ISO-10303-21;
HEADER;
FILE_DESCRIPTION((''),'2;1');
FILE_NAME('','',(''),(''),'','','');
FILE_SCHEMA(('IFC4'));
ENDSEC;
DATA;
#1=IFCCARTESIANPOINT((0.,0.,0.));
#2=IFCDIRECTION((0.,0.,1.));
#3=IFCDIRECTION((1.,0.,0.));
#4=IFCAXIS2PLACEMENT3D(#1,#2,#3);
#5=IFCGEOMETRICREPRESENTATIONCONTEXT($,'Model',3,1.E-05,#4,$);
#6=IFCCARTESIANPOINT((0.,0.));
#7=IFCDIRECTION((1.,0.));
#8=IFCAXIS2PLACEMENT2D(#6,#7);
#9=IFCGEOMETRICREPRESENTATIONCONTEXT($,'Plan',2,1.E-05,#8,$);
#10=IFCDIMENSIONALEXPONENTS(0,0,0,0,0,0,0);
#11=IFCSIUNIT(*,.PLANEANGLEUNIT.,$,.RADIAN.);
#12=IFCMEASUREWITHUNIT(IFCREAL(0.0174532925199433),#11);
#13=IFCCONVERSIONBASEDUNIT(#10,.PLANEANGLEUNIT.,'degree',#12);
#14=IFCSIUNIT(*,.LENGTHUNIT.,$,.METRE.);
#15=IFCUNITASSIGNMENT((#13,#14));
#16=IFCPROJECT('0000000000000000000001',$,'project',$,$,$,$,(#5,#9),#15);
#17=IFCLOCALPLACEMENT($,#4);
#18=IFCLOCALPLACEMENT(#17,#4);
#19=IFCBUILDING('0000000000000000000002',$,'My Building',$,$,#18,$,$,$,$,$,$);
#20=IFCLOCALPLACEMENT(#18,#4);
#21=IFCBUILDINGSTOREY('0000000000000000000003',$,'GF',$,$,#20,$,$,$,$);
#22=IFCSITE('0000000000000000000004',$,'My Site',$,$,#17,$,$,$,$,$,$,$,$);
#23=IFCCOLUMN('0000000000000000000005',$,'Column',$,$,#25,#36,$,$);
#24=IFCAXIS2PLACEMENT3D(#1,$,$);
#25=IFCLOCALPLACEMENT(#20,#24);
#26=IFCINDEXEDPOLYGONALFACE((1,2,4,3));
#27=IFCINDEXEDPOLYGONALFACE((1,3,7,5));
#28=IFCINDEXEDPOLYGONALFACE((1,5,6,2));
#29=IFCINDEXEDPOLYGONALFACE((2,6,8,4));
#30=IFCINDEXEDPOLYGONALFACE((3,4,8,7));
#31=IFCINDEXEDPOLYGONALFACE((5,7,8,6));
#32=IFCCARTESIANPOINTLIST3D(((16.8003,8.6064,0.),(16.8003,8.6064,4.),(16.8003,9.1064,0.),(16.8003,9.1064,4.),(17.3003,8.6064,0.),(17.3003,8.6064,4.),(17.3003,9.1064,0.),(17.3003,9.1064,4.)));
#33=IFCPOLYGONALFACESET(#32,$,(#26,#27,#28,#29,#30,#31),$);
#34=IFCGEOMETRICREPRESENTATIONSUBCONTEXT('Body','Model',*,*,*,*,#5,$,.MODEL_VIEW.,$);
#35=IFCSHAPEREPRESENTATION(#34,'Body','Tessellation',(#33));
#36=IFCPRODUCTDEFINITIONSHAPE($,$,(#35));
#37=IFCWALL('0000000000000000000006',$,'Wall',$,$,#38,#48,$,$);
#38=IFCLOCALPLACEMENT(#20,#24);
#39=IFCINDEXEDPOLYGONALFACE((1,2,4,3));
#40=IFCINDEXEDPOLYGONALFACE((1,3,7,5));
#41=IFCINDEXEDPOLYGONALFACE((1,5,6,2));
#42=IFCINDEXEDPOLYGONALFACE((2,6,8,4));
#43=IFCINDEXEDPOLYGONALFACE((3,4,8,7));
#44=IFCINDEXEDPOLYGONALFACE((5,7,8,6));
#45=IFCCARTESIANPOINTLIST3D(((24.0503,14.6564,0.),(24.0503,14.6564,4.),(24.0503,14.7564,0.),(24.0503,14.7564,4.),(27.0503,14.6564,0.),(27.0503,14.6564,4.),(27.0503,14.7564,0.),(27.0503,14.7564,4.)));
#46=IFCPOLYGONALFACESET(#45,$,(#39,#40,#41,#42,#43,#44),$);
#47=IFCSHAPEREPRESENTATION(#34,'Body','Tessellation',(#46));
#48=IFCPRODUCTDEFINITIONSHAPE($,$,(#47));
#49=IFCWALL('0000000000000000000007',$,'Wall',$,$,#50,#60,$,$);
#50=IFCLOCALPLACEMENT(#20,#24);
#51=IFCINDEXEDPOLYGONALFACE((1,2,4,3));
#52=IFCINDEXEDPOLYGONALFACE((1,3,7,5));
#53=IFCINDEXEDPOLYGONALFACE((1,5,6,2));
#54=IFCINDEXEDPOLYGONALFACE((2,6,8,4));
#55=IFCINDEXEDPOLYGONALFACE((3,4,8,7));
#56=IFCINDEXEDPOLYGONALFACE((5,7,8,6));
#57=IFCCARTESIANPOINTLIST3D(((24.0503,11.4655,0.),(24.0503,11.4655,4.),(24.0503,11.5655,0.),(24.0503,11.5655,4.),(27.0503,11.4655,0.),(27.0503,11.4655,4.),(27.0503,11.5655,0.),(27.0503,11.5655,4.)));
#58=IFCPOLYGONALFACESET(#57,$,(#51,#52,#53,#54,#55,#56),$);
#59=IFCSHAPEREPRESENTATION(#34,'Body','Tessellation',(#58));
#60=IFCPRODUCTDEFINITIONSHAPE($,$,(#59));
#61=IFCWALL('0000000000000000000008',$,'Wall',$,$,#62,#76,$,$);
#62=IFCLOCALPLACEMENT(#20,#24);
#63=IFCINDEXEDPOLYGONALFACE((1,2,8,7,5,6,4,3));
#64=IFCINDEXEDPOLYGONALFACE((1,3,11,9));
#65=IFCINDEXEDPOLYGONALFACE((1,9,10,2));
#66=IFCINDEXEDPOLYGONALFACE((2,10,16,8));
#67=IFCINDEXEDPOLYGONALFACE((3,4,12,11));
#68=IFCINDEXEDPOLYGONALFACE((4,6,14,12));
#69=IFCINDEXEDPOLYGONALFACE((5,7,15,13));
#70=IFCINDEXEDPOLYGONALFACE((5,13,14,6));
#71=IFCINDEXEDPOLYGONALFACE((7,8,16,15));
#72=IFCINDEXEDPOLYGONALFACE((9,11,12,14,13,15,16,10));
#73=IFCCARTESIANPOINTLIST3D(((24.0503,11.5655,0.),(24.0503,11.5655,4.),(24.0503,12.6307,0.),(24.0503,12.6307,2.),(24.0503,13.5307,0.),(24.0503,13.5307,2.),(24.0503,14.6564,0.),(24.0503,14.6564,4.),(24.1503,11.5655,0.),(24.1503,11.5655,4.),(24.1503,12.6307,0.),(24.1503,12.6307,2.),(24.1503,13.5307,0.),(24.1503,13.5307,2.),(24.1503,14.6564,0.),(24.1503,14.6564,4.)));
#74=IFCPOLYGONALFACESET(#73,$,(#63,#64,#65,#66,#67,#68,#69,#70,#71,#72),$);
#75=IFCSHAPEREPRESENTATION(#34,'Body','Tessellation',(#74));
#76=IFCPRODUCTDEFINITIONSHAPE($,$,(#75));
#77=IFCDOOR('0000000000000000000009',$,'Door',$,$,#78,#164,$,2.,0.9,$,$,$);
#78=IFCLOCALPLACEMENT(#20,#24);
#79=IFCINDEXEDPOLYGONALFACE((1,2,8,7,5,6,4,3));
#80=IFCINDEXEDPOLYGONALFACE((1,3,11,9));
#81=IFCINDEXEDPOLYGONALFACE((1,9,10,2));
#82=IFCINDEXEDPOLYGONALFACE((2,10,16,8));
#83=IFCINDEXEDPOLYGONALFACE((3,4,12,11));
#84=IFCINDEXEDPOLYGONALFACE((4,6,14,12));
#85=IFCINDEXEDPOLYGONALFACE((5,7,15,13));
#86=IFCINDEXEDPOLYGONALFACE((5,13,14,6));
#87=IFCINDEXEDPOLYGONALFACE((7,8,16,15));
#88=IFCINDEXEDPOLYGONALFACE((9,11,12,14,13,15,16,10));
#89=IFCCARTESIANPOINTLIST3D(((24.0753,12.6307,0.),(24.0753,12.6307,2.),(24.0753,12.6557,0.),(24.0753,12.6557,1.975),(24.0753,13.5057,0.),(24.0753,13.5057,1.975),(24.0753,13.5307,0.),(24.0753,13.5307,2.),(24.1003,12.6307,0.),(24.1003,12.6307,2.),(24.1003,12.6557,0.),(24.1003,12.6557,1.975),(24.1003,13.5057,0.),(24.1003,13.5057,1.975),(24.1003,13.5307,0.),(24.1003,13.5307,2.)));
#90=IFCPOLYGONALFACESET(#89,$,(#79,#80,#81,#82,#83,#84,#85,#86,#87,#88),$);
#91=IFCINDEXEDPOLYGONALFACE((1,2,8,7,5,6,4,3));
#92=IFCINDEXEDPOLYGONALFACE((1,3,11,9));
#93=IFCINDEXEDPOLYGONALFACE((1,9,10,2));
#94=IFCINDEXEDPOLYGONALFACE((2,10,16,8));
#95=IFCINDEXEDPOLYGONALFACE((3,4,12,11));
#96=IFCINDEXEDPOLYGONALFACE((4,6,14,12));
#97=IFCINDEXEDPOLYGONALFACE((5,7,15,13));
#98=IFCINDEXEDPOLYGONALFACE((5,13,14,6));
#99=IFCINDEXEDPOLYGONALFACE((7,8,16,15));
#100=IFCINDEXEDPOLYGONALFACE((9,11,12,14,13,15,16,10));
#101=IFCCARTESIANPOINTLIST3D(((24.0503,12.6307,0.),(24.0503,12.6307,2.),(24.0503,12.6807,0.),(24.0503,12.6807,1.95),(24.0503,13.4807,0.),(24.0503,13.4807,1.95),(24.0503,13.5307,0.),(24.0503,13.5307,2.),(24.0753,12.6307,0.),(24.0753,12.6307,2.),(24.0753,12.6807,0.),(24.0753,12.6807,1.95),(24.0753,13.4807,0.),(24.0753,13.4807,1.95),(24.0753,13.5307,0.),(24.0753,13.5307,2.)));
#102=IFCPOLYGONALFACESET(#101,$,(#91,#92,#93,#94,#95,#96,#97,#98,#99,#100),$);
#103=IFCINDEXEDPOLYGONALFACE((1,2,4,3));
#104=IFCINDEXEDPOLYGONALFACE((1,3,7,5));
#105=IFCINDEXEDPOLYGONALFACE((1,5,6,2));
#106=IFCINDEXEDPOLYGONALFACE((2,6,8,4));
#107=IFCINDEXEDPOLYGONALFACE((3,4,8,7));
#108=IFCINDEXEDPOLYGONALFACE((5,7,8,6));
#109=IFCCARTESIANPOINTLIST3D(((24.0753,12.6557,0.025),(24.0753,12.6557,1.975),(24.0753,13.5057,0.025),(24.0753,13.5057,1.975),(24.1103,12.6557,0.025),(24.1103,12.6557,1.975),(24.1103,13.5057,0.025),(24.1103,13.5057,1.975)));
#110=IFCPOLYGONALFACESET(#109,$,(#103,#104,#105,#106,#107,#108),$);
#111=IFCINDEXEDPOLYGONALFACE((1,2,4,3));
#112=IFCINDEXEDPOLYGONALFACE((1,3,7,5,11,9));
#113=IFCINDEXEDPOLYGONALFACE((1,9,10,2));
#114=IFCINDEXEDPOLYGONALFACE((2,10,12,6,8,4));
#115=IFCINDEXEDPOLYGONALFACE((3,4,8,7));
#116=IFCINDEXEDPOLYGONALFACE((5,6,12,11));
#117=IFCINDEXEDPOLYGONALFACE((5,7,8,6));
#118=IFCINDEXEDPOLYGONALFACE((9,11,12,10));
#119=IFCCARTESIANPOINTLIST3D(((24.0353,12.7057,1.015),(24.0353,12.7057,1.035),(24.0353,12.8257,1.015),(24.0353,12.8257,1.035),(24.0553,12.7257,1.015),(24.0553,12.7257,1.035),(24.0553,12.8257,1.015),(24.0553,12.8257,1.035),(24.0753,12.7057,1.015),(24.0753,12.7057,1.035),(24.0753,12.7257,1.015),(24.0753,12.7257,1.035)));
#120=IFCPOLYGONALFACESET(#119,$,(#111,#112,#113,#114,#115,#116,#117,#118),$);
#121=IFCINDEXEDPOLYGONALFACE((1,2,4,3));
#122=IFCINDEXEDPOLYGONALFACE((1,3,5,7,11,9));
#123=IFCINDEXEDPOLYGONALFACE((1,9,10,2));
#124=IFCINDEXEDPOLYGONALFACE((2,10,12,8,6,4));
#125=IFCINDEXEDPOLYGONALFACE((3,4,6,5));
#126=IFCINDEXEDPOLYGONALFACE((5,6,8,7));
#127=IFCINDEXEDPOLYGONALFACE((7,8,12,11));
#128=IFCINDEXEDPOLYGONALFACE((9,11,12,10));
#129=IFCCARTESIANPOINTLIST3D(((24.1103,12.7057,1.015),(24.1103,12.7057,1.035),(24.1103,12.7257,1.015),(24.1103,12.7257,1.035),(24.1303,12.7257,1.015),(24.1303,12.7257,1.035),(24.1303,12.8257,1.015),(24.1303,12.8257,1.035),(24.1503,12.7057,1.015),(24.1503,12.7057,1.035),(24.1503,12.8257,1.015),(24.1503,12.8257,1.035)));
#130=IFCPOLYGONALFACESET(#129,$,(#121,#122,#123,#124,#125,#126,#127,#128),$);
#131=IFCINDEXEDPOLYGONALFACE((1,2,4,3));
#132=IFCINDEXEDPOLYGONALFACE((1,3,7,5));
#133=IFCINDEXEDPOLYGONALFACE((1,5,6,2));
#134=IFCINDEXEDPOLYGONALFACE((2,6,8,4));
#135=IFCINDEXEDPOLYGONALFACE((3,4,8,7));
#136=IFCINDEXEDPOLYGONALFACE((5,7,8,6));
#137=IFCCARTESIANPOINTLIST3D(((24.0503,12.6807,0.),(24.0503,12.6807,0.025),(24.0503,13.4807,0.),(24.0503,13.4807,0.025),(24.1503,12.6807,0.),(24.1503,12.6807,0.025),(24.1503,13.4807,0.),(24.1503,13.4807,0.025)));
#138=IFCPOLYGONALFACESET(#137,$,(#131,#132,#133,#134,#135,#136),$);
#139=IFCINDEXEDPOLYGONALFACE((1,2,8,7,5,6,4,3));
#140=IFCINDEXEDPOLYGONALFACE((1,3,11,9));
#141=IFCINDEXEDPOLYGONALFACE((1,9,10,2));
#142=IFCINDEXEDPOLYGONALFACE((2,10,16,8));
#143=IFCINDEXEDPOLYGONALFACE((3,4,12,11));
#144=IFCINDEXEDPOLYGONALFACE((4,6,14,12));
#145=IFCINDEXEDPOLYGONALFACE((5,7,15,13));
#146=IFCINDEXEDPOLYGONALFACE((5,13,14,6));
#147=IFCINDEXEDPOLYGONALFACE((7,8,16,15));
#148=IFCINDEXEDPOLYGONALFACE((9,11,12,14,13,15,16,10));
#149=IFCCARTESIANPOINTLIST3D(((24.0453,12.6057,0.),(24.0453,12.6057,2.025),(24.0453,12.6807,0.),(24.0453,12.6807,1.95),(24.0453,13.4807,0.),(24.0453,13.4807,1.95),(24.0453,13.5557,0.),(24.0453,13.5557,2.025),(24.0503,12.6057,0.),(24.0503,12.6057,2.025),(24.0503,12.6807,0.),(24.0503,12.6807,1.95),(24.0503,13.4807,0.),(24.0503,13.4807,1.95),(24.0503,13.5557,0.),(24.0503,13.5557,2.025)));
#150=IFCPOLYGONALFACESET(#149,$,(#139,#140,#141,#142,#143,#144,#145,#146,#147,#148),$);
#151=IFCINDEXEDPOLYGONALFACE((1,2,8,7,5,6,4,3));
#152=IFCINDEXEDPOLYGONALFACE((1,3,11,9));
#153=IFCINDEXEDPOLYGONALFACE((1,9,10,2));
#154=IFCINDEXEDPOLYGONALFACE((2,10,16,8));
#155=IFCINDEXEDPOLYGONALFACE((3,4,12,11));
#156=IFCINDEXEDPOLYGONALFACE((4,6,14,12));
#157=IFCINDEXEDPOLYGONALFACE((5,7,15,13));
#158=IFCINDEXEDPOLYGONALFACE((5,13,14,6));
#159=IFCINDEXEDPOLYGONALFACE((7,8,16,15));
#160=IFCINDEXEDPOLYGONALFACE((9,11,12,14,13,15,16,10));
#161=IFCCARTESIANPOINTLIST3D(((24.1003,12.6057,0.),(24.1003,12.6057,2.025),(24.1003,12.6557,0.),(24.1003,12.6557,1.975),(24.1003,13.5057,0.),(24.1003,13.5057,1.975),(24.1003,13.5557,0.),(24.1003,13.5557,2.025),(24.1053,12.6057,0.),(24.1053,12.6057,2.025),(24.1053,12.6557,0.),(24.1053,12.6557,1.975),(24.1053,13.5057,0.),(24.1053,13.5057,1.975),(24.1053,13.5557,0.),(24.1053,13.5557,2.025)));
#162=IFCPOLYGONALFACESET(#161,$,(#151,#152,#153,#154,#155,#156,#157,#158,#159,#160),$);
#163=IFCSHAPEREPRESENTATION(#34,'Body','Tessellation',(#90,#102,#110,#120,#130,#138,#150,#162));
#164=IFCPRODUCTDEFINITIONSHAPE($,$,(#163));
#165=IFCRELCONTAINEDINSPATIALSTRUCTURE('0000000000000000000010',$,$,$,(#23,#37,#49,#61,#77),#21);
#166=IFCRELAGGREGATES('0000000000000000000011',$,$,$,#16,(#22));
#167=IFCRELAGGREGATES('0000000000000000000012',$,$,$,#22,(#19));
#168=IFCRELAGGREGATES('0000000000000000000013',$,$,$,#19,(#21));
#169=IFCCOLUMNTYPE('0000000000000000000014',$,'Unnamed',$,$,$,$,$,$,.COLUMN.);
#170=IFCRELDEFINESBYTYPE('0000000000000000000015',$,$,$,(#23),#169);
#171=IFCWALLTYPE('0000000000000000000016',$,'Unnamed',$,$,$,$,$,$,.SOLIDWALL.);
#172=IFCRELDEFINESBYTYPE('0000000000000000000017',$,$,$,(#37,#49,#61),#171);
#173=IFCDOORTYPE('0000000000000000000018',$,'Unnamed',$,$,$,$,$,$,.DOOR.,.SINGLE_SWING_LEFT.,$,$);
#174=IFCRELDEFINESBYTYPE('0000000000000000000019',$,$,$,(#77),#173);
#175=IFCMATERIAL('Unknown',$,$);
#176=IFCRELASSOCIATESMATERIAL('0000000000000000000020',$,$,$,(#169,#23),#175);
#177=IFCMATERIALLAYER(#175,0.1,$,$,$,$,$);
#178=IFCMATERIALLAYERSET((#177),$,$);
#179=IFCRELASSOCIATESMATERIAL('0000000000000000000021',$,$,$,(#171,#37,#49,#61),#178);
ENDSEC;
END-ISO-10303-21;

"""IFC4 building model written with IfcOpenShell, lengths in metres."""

from ifc_helpers import new_model, entity, si_unit, converted_unit, frame, origin_with_axes, origin_2d_with_axis, place, context, subcontext, project, spatial, line, indexed_curve, rectangle, outline, extrude, shape, source, transform, mapped, material, layer, layer_set, layer_usage, material_profile, profile_set, profile_usage, type_object, type_shapes, element, fill, save


model = new_model("IFC4")

# Units and contexts
model_context = context("Model", 3, precision=1e-05, world=origin_with_axes())
plan_context = context("Plan", 2, precision=1e-05, world=origin_2d_with_axis())
body_context_1 = subcontext(model_context, "Body", "Model", "MODEL_VIEW")
body_context_2 = subcontext(plan_context, "Body", "Plan", "PLAN_VIEW")
ifc_project = project(units=[converted_unit("PLANEANGLEUNIT", "degree", entity("IfcReal", 0.0174532925199433), si_unit("PLANEANGLEUNIT", "RADIAN"), dimensions=[0, 0, 0, 0, 0, 0, 0]), si_unit("LENGTHUNIT", "METRE")], contexts=[model_context, plan_context])

# Site, building, storey
site_placement = place(None, origin_with_axes())
site = spatial("IfcSite", under=ifc_project, at=site_placement, Name="My Site")
building_placement = place(site_placement, origin_with_axes())
building = spatial("IfcBuilding", under=site, at=building_placement, Name="My Building")
storey_placement = place(building_placement, origin_with_axes())
storey = spatial("IfcBuildingStorey", under=building, at=storey_placement, Name="GF")

# Column
ifc_material = material(Name="Unknown")
ifc_material_profile_1 = material_profile(ifc_material, rectangle(XDim=0.5, YDim=0.5))
ifc_profile_set_1 = profile_set([ifc_material_profile_1])
ifc_profile_usage_1 = profile_usage(ifc_profile_set_1, cardinal=5)
column_type = type_object("IfcColumnType", Name="Unnamed", PredefinedType="COLUMN", material=ifc_profile_set_1)
column_placement = place(storey_placement, frame((17.0503, 8.8564, 0.0), z_axis=(0.0, 0.0, 1.0), x_axis=(1.0, 0.0, 0.0)))
element("IfcColumn", 1, at=column_placement, inside=storey, type_object=column_type, material=ifc_profile_usage_1, Name="Column", context=body_context_1, shape_type="SweptSolid", body=[
    extrude(rectangle(XDim=0.5, YDim=0.5), origin_with_axes(), (0.0, 0.0, 1.0), 4.0),
])

# Walls
ifc_layer = layer(ifc_material, 0.1)
ifc_layer_set = layer_set([ifc_layer])
ifc_layer_usage_1 = layer_usage(ifc_layer_set, "AXIS2", "POSITIVE", 0.0)
wall_type = type_object("IfcWallType", Name="Unnamed", PredefinedType="SOLIDWALL", material=ifc_layer_set)
wall_1_placement = place(storey_placement, frame((24.0503, 14.6564, 0.0), z_axis=(0.0, 0.0, 1.0), x_axis=(1.0, 0.0, 0.0)))
element("IfcWall", 2, at=wall_1_placement, inside=storey, type_object=wall_type, material=ifc_layer_usage_1, Name="Wall", context=body_context_1, shape_type="SweptSolid", body=[
    extrude(outline(indexed_curve([(0.0, 0.0), (0.0, 0.1), (3.0, 0.1), (3.0, 0.0)], segments=[line(1, 2, 3, 4, 1)])), origin_with_axes(), (0.0, 0.0, 1.0), 4.0),
])
ifc_layer_usage_2 = layer_usage(ifc_layer_set, "AXIS2", "POSITIVE", 0.0)
wall_2_placement = place(storey_placement, frame((24.0503, 11.4655, 0.0), z_axis=(0.0, 0.0, 1.0), x_axis=(1.0, 0.0, 0.0)))
element("IfcWall", 3, at=wall_2_placement, inside=storey, type_object=wall_type, material=ifc_layer_usage_2, Name="Wall", context=body_context_1, shape_type="SweptSolid", body=[
    extrude(outline(indexed_curve([(0.0, 0.0), (0.0, 0.1), (3.0, 0.1), (3.0, 0.0)], segments=[line(1, 2, 3, 4, 1)])), origin_with_axes(), (0.0, 0.0, 1.0), 4.0),
])

# Wall, opening, door
ifc_layer_usage_3 = layer_usage(ifc_layer_set, "AXIS2", "POSITIVE", 0.0)
wall_3_placement = place(storey_placement, frame((24.0503, 14.6564, 0.0), z_axis=(0.0, 0.0, 1.0), x_axis=(0.0, -1.0, 0.0)))
wall_3 = element("IfcWall", 4, at=wall_3_placement, inside=storey, type_object=wall_type, material=ifc_layer_usage_3, Name="Wall", context=body_context_1, shape_type="SweptSolid", body=[
    extrude(outline(indexed_curve([(0.0, 0.0), (0.0, 0.1), (3.0909, 0.1), (3.0909, 0.0)], segments=[line(1, 2, 3, 4, 1)])), origin_with_axes(), (0.0, 0.0, 1.0), 4.0),
])
shared_shape_1 = source(origin_with_axes(), body_context_1, "Body", "SweptSolid", [
    extrude(outline(indexed_curve([(0.0, 0.0), (0.9, 0.0), (0.9, 2.0), (0.0, 2.0)], segments=[line(1, 2, 3, 4, 1)])), frame((0.0, -0.6, 0.0), z_axis=(0.0, -1.0, 0.0), x_axis=(1.0, 0.0, 0.0)), (0.0, 0.0, -1.0), 1.2),
])
opening_placement = place(wall_3_placement, frame((1.1256, 0.0, 0.0), z_axis=(0.0, 0.0, 1.0), x_axis=(1.0, 0.0, 0.0)))
opening = element("IfcOpeningElement", 5, at=opening_placement, cuts=wall_3, PredefinedType="OPENING", context=body_context_1, shape_type="MappedRepresentation", body=[
    mapped(shared_shape_1, transform((0.0, 0.0, 0.0), x_axis=(1.0, 0.0, 0.0), y_axis=(0.0, 1.0, 0.0), z_axis=(0.0, 0.0, 1.0), scale=1.0)),
])
door_type = type_object("IfcDoorType", Name="Unnamed", OperationType="SINGLE_SWING_LEFT", PredefinedType="DOOR")
shared_shape_2 = source(origin_with_axes(), body_context_1, "Body", "SweptSolid", [
    extrude(outline(indexed_curve([(0.0, 0.0), (0.0, 2.0), (0.9, 2.0), (0.9, 0.0), (0.875, 0.0), (0.875, 1.975), (0.025, 1.975), (0.025, 0.0)], segments=[line(1, 2, 3, 4, 5, 6, 7, 8, 1)])), frame((0.0, 0.025, 0.0), z_axis=(0.0, -1.0, 0.0), x_axis=(1.0, 0.0, 0.0)), (0.0, 0.0, -1.0), 0.025),
    extrude(outline(indexed_curve([(0.0, 0.0), (0.0, 2.0), (0.9, 2.0), (0.9, 0.0), (0.85, 0.0), (0.85, 1.95), (0.05, 1.95), (0.05, 0.0)], segments=[line(1, 2, 3, 4, 5, 6, 7, 8, 1)])), frame((0.0, 0.0, 0.0), z_axis=(0.0, -1.0, 0.0), x_axis=(1.0, 0.0, 0.0)), (0.0, 0.0, -1.0), 0.025),
    extrude(outline(indexed_curve([(0.0, 0.0), (0.85, 0.0), (0.85, 0.035), (0.0, 0.035)], segments=[line(1, 2, 3, 4, 1)])), frame((0.025, 0.025, 0.025), z_axis=(0.0, 0.0, 1.0), x_axis=(1.0, 0.0, 0.0)), (0.0, 0.0, 1.0), 1.95),
    extrude(outline(indexed_curve([(0.0, 0.0), (0.0, -0.04), (-0.12, -0.04), (-0.12, -0.02), (-0.02, -0.02), (-0.02, 0.0)], segments=[line(1, 2, 3, 4, 5, 6, 1)])), frame((0.825, 0.025, 1.015), z_axis=(0.0, 0.0, 1.0), x_axis=(1.0, 0.0, 0.0)), (0.0, 0.0, 1.0), 0.02),
    extrude(outline(indexed_curve([(0.0, 0.0), (0.0, 0.04), (-0.12, 0.04), (-0.12, 0.02), (-0.02, 0.02), (-0.02, 0.0)], segments=[line(1, 2, 3, 4, 5, 6, 1)])), frame((0.825, 0.06, 1.015), z_axis=(0.0, 0.0, 1.0), x_axis=(1.0, 0.0, 0.0)), (0.0, 0.0, 1.0), 0.02),
    extrude(outline(indexed_curve([(0.0, 0.0), (0.8, 0.0), (0.8, 0.1), (0.0, 0.1)], segments=[line(1, 2, 3, 4, 1)])), frame((0.05, 0.0, 0.0), z_axis=(0.0, 0.0, 1.0), x_axis=(1.0, 0.0, 0.0)), (0.0, 0.0, 1.0), 0.025),
    extrude(outline(indexed_curve([(0.0, 0.0), (0.0, 2.025), (0.95, 2.025), (0.95, 0.0), (0.875, 0.0), (0.875, 1.95), (0.075, 1.95), (0.075, 0.0)], segments=[line(1, 2, 3, 4, 5, 6, 7, 8, 1)])), frame((-0.025, -0.005, 0.0), z_axis=(0.0, -1.0, 0.0), x_axis=(1.0, 0.0, 0.0)), (0.0, 0.0, -1.0), 0.005),
    extrude(outline(indexed_curve([(0.0, 0.0), (0.0, 2.025), (0.95, 2.025), (0.95, 0.0), (0.9, 0.0), (0.9, 1.975), (0.05, 1.975), (0.05, 0.0)], segments=[line(1, 2, 3, 4, 5, 6, 7, 8, 1)])), frame((-0.025, 0.05, 0.0), z_axis=(0.0, -1.0, 0.0), x_axis=(1.0, 0.0, 0.0)), (0.0, 0.0, -1.0), 0.005),
])
shared_shape_3 = source(origin_with_axes(), body_context_2, "Body", "Curve2D", [
    entity("IfcIndexedPolyCurve", entity("IfcCartesianPointList2D", [[0.0, 0.0], [0.0, 0.05], [0.025, 0.05], [0.025, 0.025], [0.05, 0.025], [0.05, 0.0]]), [entity("IfcLineIndex", [1, 2, 3, 4, 5, 6, 1])]),
    entity("IfcIndexedPolyCurve", entity("IfcCartesianPointList2D", [[0.9, 0.0], [0.9, 0.05], [0.875, 0.05], [0.875, 0.025], [0.85, 0.025], [0.85, 0.0]]), [entity("IfcLineIndex", [1, 2, 3, 4, 5, 6, 1])]),
    entity("IfcTrimmedCurve", entity("IfcEllipse", entity("IfcAxis2Placement2D", entity("IfcCartesianPoint", [0.06, 0.05]), entity("IfcDirection", [1.0, 0.0])), 0.815, 0.85), [entity("IfcCartesianPoint", [0.875, 0.05])], [entity("IfcCartesianPoint", [0.06, 0.9])], True, "CARTESIAN"),
    entity("IfcIndexedPolyCurve", entity("IfcCartesianPointList2D", [[0.025, 0.05], [0.06, 0.05], [0.06, 0.9], [0.025, 0.9]]), [entity("IfcLineIndex", [1, 2, 3, 4, 1])]),
])
type_shapes(door_type, [shared_shape_2, shared_shape_3])
door_1_placement = place(opening_placement, frame((0.0, 0.0, 0.0), z_axis=(0.0, 0.0, 1.0), x_axis=(1.0, 0.0, 0.0)))
door_1 = element("IfcDoor", 6, at=door_1_placement, inside=storey, type_object=door_type, Name="Door", OverallHeight=2.0, OverallWidth=0.9, shapes=[
    shape(body_context_1, "Body", "MappedRepresentation", [mapped(shared_shape_2, transform((0.0, 0.0, 0.0), x_axis=(1.0, 0.0, 0.0), y_axis=(0.0, 1.0, 0.0), z_axis=(0.0, 0.0, 1.0), scale=1.0))]),
    shape(body_context_2, "Body", "MappedRepresentation", [mapped(shared_shape_3, transform((0.0, 0.0, 0.0), x_axis=(1.0, 0.0, 0.0), y_axis=(0.0, 1.0, 0.0), z_axis=(0.0, 0.0, 1.0), scale=1.0))]),
])
fill(opening, door_1)

save(model, "model.ifc")
